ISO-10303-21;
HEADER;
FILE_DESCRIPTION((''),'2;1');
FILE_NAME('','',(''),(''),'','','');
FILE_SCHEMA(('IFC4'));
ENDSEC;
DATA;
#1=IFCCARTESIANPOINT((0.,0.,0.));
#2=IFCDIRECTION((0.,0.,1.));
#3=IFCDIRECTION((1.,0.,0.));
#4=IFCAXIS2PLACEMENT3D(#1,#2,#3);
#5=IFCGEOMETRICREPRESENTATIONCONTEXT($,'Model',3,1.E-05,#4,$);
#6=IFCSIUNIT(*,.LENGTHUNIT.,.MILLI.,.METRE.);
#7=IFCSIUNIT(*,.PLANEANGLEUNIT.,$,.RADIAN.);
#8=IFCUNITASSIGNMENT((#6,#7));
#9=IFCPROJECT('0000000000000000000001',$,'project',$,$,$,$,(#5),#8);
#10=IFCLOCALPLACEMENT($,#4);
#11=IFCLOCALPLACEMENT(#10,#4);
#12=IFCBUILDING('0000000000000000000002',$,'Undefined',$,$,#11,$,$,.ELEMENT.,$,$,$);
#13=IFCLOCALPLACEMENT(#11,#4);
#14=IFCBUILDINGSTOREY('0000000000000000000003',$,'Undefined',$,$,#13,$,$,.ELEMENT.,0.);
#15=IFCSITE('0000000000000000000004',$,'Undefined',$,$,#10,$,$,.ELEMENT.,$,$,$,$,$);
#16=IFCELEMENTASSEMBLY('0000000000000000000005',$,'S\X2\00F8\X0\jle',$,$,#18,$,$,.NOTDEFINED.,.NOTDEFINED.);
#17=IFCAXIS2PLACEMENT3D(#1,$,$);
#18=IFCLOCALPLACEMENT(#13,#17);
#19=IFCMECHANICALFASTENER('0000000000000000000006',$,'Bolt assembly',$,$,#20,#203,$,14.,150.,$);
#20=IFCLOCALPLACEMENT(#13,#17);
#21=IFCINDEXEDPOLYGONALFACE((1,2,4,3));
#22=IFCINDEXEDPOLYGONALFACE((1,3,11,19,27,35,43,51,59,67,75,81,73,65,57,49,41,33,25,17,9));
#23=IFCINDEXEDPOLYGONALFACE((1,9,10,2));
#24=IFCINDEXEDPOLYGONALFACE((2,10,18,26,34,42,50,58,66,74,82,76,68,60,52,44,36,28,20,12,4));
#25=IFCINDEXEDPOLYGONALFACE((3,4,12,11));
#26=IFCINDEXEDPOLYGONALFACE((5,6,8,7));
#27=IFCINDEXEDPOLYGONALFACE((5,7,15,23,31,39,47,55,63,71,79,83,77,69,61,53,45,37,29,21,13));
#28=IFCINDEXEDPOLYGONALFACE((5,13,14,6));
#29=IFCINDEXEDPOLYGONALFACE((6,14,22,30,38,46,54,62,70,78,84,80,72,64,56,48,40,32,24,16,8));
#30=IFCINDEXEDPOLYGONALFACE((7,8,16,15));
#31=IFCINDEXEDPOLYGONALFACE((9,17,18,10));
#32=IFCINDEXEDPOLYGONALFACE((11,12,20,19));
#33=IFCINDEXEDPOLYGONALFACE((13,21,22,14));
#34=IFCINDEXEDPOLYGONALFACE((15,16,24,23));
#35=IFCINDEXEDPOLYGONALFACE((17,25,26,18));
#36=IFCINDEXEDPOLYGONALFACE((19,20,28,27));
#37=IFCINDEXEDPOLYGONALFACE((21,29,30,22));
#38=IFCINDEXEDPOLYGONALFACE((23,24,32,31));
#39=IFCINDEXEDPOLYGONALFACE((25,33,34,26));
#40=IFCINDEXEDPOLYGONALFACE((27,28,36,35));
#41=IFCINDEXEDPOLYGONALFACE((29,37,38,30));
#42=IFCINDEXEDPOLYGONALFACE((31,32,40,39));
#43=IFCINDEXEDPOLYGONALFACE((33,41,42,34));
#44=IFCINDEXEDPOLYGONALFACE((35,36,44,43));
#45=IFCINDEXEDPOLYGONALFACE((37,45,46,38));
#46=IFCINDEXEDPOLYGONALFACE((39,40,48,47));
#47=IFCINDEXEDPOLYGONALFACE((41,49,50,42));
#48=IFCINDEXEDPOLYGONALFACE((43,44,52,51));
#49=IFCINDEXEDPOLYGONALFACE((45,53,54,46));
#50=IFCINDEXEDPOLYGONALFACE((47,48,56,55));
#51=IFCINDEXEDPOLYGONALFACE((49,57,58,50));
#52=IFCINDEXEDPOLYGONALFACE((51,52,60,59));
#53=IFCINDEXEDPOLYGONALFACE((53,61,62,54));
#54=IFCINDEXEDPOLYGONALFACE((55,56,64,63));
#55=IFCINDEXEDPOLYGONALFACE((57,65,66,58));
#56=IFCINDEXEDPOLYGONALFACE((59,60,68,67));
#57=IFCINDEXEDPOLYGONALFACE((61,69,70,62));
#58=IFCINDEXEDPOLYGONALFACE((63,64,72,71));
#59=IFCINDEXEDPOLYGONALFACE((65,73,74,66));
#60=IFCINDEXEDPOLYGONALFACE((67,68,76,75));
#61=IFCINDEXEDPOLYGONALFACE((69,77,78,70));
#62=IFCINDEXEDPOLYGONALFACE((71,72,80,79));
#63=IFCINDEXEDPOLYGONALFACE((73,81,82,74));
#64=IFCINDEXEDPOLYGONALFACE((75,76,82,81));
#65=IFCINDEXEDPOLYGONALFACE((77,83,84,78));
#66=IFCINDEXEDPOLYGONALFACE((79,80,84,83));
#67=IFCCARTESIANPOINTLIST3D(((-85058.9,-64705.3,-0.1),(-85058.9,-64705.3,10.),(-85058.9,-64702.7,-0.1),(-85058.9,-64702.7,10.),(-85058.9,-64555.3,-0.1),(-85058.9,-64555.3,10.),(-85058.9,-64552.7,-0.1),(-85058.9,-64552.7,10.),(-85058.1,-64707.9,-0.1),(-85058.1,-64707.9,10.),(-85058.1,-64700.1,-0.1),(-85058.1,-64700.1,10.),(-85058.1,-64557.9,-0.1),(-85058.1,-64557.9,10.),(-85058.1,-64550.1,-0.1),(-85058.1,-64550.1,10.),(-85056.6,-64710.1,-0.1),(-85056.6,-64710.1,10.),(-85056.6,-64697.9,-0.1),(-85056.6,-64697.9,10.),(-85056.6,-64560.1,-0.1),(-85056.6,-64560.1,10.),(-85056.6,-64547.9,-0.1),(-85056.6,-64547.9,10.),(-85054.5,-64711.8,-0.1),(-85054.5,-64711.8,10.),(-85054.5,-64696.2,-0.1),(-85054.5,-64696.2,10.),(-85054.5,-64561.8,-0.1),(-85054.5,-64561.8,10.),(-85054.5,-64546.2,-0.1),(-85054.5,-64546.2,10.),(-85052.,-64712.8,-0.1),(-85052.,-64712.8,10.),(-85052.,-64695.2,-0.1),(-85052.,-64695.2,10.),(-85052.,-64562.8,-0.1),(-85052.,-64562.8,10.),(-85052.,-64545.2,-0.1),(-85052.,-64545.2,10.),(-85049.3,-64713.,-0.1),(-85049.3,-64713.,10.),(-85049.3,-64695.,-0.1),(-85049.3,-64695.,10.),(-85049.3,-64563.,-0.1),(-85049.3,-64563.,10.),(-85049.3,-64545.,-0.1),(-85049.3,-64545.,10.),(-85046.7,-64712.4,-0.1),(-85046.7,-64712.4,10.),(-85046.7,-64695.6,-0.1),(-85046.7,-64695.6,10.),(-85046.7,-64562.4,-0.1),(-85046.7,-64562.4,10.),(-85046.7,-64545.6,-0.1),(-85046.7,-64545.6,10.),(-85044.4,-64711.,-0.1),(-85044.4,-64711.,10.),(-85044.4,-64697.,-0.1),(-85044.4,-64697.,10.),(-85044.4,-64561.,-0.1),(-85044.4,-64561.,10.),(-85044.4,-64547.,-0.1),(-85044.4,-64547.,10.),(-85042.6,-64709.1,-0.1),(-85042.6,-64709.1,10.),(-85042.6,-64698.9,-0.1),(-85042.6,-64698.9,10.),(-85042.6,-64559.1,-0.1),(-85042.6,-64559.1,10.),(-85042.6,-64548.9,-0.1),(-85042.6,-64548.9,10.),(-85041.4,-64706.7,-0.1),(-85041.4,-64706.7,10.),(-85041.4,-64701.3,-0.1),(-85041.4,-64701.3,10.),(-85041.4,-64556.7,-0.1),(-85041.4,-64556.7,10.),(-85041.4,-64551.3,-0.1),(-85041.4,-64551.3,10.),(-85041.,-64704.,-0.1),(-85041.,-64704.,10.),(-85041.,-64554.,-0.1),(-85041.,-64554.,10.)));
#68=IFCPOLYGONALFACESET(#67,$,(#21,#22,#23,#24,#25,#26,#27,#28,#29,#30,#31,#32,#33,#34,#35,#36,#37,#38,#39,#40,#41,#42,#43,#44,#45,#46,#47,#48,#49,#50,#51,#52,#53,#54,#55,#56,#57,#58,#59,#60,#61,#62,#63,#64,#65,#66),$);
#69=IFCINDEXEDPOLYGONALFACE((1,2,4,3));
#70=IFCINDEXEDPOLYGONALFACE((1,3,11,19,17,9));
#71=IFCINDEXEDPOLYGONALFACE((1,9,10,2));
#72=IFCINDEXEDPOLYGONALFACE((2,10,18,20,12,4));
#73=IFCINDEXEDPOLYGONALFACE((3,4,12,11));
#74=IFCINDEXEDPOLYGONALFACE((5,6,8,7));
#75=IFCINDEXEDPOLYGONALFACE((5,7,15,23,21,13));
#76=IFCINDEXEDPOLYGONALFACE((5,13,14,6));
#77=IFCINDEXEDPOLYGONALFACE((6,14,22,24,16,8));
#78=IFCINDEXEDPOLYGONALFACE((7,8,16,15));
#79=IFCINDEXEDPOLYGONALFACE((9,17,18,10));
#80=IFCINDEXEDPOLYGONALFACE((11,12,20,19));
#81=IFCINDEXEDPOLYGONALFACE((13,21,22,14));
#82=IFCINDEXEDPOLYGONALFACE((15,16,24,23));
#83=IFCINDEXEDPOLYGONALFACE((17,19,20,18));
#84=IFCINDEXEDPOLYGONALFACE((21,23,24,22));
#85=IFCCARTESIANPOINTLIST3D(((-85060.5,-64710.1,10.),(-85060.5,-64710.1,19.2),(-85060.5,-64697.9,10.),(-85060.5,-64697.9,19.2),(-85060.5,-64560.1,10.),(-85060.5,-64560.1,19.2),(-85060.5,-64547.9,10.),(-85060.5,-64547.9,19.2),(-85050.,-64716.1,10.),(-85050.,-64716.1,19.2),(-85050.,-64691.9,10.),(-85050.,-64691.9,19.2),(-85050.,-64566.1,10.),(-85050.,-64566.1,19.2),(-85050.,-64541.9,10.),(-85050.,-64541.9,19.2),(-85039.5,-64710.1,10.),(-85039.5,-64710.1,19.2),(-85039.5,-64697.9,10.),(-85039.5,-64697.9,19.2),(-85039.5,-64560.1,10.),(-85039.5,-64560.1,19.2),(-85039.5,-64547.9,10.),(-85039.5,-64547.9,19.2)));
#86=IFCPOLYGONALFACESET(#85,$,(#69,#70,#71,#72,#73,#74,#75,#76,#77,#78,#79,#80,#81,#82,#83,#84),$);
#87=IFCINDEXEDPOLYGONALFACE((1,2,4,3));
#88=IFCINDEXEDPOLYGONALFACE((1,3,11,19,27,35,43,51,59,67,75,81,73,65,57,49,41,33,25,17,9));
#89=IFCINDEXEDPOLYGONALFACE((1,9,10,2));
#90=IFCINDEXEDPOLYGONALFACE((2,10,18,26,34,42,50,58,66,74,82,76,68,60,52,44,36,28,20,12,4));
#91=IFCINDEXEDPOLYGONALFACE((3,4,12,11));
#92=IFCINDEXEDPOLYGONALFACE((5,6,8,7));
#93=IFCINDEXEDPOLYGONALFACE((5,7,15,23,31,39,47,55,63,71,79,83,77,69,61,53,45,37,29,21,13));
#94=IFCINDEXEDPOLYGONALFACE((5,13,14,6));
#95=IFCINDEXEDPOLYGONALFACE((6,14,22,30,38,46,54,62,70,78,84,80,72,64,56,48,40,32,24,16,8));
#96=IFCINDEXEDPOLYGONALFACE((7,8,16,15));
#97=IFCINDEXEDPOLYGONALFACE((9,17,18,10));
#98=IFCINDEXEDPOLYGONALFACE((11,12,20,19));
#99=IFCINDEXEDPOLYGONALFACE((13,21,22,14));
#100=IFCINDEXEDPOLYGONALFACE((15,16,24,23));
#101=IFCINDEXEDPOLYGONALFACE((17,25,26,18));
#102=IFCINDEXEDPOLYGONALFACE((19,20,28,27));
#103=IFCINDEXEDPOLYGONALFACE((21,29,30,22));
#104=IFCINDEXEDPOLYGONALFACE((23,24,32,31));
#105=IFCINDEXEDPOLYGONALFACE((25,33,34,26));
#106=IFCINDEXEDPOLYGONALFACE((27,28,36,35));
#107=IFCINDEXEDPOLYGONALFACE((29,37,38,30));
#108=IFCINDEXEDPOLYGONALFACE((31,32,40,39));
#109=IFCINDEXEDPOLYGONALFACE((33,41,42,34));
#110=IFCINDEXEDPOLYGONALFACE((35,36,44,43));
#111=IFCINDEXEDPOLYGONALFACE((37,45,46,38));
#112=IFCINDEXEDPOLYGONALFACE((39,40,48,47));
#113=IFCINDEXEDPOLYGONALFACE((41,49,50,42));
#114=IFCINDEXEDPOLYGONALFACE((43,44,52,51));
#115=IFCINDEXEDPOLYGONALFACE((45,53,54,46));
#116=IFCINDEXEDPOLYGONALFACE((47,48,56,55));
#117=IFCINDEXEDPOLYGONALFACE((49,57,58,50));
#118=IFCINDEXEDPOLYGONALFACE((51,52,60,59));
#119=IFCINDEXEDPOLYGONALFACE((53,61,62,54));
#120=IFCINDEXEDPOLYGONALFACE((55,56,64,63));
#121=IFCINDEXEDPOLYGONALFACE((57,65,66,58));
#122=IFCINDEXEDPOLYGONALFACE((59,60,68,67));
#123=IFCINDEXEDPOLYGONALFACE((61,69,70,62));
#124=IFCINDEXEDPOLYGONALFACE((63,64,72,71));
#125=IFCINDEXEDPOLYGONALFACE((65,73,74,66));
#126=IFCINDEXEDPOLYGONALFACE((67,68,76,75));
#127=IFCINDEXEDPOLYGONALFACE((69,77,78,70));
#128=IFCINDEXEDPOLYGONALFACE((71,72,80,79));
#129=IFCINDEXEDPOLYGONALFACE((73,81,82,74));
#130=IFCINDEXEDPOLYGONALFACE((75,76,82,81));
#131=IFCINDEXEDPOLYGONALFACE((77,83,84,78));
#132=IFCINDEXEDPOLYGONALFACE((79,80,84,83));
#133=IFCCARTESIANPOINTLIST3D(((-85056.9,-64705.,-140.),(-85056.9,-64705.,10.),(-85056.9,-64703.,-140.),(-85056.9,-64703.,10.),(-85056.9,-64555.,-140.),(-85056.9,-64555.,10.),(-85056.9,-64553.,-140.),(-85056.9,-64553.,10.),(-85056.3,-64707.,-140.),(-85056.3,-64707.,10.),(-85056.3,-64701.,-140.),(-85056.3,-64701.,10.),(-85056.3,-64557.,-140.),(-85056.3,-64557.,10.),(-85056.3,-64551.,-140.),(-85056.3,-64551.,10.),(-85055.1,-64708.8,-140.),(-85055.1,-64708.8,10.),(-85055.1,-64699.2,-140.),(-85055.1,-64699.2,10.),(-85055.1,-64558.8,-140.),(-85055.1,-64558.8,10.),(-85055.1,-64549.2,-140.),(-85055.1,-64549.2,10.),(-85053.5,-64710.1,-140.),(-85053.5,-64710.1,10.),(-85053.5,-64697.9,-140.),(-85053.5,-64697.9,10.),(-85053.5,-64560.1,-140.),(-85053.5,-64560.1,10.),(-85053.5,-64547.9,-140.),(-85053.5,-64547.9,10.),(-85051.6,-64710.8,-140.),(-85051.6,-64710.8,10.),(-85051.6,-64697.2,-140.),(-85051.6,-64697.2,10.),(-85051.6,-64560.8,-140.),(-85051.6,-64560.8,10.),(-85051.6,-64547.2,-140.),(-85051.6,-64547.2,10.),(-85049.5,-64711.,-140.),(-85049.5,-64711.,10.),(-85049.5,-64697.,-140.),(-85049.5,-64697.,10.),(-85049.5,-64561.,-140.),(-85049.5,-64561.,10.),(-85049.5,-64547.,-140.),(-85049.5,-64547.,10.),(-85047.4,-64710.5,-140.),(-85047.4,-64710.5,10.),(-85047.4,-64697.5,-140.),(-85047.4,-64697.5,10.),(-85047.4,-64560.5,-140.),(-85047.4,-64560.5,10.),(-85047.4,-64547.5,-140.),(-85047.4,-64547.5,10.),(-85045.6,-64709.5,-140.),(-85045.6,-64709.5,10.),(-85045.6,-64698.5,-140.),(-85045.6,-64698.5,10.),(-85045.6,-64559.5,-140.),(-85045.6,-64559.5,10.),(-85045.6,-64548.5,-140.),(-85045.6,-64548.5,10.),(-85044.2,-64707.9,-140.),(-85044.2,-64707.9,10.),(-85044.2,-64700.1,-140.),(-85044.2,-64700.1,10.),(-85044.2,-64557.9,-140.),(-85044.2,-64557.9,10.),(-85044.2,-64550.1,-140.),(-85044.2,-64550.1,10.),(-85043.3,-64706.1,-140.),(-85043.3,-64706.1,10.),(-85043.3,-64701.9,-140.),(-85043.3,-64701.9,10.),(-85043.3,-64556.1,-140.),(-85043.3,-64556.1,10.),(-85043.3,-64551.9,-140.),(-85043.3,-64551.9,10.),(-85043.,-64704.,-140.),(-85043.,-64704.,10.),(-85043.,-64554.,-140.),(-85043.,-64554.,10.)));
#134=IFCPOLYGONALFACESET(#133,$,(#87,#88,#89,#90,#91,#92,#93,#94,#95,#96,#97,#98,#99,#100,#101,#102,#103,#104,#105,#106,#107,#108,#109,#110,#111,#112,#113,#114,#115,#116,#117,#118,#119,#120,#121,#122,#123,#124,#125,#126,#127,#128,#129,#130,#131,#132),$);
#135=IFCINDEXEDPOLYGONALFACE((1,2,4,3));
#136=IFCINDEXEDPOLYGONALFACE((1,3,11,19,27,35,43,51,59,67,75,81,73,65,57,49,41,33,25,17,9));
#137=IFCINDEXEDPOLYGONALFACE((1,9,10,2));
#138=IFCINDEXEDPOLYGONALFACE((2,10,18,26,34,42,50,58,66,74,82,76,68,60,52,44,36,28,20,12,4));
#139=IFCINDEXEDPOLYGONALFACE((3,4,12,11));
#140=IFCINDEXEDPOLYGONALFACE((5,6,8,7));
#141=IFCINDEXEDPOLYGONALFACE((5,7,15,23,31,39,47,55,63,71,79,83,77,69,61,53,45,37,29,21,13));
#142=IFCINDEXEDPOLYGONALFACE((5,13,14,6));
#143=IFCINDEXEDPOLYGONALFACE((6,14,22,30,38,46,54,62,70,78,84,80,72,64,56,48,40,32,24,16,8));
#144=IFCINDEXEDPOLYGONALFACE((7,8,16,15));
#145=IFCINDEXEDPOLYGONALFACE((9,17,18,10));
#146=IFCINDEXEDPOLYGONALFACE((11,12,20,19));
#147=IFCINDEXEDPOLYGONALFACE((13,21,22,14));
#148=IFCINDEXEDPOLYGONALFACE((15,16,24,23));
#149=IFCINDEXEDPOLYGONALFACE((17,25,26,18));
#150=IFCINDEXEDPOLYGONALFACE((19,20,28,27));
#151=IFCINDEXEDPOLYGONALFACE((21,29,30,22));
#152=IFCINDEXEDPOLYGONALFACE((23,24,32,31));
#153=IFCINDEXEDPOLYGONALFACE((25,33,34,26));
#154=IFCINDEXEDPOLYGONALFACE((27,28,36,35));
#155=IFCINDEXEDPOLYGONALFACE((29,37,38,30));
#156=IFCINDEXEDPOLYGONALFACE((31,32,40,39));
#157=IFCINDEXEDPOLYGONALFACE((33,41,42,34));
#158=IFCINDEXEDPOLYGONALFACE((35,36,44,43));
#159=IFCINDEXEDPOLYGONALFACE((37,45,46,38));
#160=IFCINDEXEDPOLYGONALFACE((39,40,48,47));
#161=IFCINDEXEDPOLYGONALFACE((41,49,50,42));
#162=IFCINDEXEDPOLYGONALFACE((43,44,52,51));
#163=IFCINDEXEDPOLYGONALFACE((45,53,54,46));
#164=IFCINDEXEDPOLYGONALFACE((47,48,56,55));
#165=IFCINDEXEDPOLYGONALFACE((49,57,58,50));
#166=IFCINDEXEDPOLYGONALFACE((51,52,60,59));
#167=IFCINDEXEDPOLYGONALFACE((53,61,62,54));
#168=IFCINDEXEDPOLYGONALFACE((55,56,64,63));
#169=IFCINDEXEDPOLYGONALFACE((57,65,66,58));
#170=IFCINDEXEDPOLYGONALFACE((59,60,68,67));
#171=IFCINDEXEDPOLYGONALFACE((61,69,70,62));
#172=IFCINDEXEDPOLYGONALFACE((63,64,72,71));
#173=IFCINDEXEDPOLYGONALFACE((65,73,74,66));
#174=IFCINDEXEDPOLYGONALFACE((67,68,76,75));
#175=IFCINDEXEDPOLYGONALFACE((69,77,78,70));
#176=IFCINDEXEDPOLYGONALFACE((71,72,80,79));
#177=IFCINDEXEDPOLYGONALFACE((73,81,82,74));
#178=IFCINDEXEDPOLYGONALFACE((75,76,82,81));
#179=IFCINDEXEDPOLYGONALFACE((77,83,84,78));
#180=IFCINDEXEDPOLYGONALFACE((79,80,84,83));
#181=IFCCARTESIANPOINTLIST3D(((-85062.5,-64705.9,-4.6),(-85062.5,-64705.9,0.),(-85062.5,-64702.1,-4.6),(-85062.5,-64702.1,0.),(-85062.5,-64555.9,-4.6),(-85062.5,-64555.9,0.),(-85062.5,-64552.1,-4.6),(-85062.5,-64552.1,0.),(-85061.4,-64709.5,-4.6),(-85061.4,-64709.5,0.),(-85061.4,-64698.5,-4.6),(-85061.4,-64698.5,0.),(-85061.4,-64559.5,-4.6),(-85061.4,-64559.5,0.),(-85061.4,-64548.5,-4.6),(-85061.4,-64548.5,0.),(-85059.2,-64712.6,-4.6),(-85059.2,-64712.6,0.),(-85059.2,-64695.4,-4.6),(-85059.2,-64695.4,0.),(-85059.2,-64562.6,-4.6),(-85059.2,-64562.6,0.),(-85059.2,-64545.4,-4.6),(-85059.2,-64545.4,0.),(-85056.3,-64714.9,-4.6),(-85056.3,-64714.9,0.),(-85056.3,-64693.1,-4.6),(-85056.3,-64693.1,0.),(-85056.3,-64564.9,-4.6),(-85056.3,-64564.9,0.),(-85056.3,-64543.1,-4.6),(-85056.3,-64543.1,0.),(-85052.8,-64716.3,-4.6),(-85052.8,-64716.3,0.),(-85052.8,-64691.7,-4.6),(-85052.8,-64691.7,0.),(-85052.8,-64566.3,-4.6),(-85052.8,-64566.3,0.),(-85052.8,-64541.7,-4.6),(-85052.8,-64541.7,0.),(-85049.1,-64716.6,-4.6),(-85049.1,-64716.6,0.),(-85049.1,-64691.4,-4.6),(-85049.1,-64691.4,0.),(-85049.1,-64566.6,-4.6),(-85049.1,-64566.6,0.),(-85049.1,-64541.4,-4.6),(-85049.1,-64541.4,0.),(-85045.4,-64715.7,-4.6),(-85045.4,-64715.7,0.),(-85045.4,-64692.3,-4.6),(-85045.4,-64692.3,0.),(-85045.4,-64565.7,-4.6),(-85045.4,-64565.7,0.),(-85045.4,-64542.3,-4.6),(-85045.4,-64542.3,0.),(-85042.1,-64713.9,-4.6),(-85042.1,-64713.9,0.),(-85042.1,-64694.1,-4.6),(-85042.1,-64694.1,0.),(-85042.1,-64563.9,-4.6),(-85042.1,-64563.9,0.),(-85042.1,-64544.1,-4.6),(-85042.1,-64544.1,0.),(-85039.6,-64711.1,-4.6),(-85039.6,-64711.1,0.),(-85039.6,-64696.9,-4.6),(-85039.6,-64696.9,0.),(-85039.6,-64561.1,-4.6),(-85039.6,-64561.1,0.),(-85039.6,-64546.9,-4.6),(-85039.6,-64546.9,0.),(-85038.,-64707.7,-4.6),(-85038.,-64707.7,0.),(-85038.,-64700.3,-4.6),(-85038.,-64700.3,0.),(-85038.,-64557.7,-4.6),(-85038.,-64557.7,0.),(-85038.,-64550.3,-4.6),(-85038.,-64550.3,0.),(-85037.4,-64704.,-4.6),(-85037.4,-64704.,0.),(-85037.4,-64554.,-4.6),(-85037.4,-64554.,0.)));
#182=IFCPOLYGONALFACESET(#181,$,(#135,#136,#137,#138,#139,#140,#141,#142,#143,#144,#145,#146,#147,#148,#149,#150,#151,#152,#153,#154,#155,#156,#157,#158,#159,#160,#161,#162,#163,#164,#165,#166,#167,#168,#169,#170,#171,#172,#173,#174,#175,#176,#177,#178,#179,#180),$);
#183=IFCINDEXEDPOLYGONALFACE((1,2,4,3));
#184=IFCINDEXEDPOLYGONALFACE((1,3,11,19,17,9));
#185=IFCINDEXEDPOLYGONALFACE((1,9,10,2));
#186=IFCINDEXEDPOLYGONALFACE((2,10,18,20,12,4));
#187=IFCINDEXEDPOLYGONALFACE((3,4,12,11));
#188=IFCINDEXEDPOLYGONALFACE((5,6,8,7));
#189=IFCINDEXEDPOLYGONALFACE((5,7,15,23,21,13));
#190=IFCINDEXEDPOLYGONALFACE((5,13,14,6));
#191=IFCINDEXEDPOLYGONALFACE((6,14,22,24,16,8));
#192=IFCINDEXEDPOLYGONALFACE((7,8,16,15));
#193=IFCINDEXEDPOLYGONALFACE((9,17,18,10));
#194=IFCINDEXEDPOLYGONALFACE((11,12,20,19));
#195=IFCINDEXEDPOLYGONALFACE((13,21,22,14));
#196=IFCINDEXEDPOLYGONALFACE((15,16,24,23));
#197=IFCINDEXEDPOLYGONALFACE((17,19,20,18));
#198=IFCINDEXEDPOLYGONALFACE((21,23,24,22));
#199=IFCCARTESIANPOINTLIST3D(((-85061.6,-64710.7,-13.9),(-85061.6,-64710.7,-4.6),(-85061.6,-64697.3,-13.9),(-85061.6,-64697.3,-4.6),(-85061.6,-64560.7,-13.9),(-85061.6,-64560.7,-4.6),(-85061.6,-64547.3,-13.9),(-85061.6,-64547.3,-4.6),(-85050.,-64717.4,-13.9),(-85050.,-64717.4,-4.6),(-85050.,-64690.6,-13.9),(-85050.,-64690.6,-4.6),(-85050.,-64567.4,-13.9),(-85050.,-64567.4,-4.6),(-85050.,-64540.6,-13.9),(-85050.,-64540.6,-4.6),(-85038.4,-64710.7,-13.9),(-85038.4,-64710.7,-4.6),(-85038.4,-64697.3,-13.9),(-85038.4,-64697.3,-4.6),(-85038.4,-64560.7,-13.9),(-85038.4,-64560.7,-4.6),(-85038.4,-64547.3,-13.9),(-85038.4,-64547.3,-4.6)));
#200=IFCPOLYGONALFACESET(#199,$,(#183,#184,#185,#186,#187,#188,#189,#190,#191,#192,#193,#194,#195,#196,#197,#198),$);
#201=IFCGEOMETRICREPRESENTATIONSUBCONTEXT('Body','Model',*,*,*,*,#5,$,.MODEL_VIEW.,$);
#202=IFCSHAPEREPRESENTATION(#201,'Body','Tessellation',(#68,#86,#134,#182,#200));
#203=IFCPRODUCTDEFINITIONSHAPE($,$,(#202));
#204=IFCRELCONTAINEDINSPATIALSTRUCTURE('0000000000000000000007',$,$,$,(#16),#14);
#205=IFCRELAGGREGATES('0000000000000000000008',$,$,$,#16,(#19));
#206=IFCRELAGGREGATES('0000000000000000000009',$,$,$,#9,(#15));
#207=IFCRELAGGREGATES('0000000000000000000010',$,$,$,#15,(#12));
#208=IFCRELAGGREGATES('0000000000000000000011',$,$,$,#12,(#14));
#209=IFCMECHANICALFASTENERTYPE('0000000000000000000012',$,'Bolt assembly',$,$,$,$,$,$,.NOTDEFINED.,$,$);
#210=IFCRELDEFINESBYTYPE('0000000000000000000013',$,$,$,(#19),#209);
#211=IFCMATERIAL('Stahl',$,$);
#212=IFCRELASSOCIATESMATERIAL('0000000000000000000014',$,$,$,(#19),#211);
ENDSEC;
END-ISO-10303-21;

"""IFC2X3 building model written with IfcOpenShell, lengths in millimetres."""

from ifc_helpers import new_model, si_unit, frame, origin_with_axes, origin_2d_with_axis, place, context, subcontext, project, spatial, polyline, circle, outline, extrude, source, transform, mapped, material, type_object, element, aggregate, save


model = new_model("IFC2X3")

# Units and contexts
model_context = context("Model", 3, precision=1e-05, world=origin_with_axes())
body_context = subcontext(model_context, "Body", "Model", "MODEL_VIEW")
ifc_project = project(units=[si_unit("LENGTHUNIT", "METRE", prefix="MILLI"), si_unit("PLANEANGLEUNIT", "RADIAN")], contexts=[model_context])

# Site, building, storey
site_placement = place(None, origin_with_axes())
site = spatial("IfcSite", under=ifc_project, at=site_placement, Name="Undefined", CompositionType="ELEMENT")
building_placement = place(site_placement, origin_with_axes())
building = spatial("IfcBuilding", under=site, at=building_placement, Name="Undefined", CompositionType="ELEMENT")
storey_placement = place(building_placement, origin_with_axes())
storey = spatial("IfcBuildingStorey", under=building, at=storey_placement, Name="Undefined", CompositionType="ELEMENT", Elevation=0.0)

# Shared definitions
mechanical_fastener_type = type_object("IfcMechanicalFastenerType", Name="Bolt assembly")

# Element assembly
assembly_1_placement = place(storey_placement, origin_with_axes())
assembly_1 = element("IfcElementAssembly", 1, at=assembly_1_placement, inside=storey, Name="Søjle", AssemblyPlace="NOTDEFINED", PredefinedType="NOTDEFINED")

# Mechanical fastener
ifc_material_1 = material(Name="Stahl")
shared_shape_1 = source(origin_with_axes(), body_context, "Body", "SweptSolid", [
    extrude(circle(Radius=9.0, at=origin_2d_with_axis()), frame((0.0, 0.0, 0.0), z_axis=(0.0, 1.0, 0.0), x_axis=(1.0, 0.0, 0.0)), (0.0, 0.0, 1.0), 10.1),
    extrude(outline(polyline([(10.5, -6.1), (10.5, 6.1), (0.0, 12.1), (-10.5, 6.1), (-10.5, -6.1), (0.0, -12.1), (10.5, -6.1)])), frame((0.0, -9.2, 0.0), z_axis=(0.0, 1.0, 0.0), x_axis=(1.0, 0.0, 0.0)), (0.0, 0.0, 1.0), 9.2),
    extrude(circle(Radius=7.0, at=origin_2d_with_axis()), frame((0.0, 0.0, 0.0), z_axis=(0.0, 1.0, 0.0), x_axis=(1.0, 0.0, 0.0)), (0.0, 0.0, 1.0), 150.0),
    extrude(circle(Radius=12.6, at=origin_2d_with_axis()), frame((0.0, 10.0, 0.0), z_axis=(0.0, 1.0, 0.0), x_axis=(1.0, 0.0, 0.0)), (0.0, 0.0, 1.0), 4.6),
    extrude(outline(polyline([(11.6, -6.7), (11.6, 6.7), (0.0, 13.4), (-11.6, 6.7), (-11.6, -6.7), (0.0, -13.4), (11.6, -6.7)])), frame((0.0, 14.6, 0.0), z_axis=(0.0, 1.0, 0.0), x_axis=(1.0, 0.0, 0.0)), (0.0, 0.0, 1.0), 9.2),
])
mechanical_fastener_1_placement = place(assembly_1_placement, frame((-85050.0, -64629.0, 10.0), z_axis=(0.0, 1.0, 0.0), x_axis=(1.0, 0.0, 0.0)))
mechanical_fastener_1 = element("IfcMechanicalFastener", 2, at=mechanical_fastener_1_placement, type_object=mechanical_fastener_type, material=ifc_material_1, Name="Bolt assembly", NominalDiameter=14.0, NominalLength=150.0, context=body_context, shape_type="MappedRepresentation", body=[
    mapped(shared_shape_1, transform((0.0, 0.0, -75.0))),
    mapped(shared_shape_1, transform((0.0, 0.0, 75.0))),
])
aggregate(assembly_1, [mechanical_fastener_1])

save(model, "model.ifc")
